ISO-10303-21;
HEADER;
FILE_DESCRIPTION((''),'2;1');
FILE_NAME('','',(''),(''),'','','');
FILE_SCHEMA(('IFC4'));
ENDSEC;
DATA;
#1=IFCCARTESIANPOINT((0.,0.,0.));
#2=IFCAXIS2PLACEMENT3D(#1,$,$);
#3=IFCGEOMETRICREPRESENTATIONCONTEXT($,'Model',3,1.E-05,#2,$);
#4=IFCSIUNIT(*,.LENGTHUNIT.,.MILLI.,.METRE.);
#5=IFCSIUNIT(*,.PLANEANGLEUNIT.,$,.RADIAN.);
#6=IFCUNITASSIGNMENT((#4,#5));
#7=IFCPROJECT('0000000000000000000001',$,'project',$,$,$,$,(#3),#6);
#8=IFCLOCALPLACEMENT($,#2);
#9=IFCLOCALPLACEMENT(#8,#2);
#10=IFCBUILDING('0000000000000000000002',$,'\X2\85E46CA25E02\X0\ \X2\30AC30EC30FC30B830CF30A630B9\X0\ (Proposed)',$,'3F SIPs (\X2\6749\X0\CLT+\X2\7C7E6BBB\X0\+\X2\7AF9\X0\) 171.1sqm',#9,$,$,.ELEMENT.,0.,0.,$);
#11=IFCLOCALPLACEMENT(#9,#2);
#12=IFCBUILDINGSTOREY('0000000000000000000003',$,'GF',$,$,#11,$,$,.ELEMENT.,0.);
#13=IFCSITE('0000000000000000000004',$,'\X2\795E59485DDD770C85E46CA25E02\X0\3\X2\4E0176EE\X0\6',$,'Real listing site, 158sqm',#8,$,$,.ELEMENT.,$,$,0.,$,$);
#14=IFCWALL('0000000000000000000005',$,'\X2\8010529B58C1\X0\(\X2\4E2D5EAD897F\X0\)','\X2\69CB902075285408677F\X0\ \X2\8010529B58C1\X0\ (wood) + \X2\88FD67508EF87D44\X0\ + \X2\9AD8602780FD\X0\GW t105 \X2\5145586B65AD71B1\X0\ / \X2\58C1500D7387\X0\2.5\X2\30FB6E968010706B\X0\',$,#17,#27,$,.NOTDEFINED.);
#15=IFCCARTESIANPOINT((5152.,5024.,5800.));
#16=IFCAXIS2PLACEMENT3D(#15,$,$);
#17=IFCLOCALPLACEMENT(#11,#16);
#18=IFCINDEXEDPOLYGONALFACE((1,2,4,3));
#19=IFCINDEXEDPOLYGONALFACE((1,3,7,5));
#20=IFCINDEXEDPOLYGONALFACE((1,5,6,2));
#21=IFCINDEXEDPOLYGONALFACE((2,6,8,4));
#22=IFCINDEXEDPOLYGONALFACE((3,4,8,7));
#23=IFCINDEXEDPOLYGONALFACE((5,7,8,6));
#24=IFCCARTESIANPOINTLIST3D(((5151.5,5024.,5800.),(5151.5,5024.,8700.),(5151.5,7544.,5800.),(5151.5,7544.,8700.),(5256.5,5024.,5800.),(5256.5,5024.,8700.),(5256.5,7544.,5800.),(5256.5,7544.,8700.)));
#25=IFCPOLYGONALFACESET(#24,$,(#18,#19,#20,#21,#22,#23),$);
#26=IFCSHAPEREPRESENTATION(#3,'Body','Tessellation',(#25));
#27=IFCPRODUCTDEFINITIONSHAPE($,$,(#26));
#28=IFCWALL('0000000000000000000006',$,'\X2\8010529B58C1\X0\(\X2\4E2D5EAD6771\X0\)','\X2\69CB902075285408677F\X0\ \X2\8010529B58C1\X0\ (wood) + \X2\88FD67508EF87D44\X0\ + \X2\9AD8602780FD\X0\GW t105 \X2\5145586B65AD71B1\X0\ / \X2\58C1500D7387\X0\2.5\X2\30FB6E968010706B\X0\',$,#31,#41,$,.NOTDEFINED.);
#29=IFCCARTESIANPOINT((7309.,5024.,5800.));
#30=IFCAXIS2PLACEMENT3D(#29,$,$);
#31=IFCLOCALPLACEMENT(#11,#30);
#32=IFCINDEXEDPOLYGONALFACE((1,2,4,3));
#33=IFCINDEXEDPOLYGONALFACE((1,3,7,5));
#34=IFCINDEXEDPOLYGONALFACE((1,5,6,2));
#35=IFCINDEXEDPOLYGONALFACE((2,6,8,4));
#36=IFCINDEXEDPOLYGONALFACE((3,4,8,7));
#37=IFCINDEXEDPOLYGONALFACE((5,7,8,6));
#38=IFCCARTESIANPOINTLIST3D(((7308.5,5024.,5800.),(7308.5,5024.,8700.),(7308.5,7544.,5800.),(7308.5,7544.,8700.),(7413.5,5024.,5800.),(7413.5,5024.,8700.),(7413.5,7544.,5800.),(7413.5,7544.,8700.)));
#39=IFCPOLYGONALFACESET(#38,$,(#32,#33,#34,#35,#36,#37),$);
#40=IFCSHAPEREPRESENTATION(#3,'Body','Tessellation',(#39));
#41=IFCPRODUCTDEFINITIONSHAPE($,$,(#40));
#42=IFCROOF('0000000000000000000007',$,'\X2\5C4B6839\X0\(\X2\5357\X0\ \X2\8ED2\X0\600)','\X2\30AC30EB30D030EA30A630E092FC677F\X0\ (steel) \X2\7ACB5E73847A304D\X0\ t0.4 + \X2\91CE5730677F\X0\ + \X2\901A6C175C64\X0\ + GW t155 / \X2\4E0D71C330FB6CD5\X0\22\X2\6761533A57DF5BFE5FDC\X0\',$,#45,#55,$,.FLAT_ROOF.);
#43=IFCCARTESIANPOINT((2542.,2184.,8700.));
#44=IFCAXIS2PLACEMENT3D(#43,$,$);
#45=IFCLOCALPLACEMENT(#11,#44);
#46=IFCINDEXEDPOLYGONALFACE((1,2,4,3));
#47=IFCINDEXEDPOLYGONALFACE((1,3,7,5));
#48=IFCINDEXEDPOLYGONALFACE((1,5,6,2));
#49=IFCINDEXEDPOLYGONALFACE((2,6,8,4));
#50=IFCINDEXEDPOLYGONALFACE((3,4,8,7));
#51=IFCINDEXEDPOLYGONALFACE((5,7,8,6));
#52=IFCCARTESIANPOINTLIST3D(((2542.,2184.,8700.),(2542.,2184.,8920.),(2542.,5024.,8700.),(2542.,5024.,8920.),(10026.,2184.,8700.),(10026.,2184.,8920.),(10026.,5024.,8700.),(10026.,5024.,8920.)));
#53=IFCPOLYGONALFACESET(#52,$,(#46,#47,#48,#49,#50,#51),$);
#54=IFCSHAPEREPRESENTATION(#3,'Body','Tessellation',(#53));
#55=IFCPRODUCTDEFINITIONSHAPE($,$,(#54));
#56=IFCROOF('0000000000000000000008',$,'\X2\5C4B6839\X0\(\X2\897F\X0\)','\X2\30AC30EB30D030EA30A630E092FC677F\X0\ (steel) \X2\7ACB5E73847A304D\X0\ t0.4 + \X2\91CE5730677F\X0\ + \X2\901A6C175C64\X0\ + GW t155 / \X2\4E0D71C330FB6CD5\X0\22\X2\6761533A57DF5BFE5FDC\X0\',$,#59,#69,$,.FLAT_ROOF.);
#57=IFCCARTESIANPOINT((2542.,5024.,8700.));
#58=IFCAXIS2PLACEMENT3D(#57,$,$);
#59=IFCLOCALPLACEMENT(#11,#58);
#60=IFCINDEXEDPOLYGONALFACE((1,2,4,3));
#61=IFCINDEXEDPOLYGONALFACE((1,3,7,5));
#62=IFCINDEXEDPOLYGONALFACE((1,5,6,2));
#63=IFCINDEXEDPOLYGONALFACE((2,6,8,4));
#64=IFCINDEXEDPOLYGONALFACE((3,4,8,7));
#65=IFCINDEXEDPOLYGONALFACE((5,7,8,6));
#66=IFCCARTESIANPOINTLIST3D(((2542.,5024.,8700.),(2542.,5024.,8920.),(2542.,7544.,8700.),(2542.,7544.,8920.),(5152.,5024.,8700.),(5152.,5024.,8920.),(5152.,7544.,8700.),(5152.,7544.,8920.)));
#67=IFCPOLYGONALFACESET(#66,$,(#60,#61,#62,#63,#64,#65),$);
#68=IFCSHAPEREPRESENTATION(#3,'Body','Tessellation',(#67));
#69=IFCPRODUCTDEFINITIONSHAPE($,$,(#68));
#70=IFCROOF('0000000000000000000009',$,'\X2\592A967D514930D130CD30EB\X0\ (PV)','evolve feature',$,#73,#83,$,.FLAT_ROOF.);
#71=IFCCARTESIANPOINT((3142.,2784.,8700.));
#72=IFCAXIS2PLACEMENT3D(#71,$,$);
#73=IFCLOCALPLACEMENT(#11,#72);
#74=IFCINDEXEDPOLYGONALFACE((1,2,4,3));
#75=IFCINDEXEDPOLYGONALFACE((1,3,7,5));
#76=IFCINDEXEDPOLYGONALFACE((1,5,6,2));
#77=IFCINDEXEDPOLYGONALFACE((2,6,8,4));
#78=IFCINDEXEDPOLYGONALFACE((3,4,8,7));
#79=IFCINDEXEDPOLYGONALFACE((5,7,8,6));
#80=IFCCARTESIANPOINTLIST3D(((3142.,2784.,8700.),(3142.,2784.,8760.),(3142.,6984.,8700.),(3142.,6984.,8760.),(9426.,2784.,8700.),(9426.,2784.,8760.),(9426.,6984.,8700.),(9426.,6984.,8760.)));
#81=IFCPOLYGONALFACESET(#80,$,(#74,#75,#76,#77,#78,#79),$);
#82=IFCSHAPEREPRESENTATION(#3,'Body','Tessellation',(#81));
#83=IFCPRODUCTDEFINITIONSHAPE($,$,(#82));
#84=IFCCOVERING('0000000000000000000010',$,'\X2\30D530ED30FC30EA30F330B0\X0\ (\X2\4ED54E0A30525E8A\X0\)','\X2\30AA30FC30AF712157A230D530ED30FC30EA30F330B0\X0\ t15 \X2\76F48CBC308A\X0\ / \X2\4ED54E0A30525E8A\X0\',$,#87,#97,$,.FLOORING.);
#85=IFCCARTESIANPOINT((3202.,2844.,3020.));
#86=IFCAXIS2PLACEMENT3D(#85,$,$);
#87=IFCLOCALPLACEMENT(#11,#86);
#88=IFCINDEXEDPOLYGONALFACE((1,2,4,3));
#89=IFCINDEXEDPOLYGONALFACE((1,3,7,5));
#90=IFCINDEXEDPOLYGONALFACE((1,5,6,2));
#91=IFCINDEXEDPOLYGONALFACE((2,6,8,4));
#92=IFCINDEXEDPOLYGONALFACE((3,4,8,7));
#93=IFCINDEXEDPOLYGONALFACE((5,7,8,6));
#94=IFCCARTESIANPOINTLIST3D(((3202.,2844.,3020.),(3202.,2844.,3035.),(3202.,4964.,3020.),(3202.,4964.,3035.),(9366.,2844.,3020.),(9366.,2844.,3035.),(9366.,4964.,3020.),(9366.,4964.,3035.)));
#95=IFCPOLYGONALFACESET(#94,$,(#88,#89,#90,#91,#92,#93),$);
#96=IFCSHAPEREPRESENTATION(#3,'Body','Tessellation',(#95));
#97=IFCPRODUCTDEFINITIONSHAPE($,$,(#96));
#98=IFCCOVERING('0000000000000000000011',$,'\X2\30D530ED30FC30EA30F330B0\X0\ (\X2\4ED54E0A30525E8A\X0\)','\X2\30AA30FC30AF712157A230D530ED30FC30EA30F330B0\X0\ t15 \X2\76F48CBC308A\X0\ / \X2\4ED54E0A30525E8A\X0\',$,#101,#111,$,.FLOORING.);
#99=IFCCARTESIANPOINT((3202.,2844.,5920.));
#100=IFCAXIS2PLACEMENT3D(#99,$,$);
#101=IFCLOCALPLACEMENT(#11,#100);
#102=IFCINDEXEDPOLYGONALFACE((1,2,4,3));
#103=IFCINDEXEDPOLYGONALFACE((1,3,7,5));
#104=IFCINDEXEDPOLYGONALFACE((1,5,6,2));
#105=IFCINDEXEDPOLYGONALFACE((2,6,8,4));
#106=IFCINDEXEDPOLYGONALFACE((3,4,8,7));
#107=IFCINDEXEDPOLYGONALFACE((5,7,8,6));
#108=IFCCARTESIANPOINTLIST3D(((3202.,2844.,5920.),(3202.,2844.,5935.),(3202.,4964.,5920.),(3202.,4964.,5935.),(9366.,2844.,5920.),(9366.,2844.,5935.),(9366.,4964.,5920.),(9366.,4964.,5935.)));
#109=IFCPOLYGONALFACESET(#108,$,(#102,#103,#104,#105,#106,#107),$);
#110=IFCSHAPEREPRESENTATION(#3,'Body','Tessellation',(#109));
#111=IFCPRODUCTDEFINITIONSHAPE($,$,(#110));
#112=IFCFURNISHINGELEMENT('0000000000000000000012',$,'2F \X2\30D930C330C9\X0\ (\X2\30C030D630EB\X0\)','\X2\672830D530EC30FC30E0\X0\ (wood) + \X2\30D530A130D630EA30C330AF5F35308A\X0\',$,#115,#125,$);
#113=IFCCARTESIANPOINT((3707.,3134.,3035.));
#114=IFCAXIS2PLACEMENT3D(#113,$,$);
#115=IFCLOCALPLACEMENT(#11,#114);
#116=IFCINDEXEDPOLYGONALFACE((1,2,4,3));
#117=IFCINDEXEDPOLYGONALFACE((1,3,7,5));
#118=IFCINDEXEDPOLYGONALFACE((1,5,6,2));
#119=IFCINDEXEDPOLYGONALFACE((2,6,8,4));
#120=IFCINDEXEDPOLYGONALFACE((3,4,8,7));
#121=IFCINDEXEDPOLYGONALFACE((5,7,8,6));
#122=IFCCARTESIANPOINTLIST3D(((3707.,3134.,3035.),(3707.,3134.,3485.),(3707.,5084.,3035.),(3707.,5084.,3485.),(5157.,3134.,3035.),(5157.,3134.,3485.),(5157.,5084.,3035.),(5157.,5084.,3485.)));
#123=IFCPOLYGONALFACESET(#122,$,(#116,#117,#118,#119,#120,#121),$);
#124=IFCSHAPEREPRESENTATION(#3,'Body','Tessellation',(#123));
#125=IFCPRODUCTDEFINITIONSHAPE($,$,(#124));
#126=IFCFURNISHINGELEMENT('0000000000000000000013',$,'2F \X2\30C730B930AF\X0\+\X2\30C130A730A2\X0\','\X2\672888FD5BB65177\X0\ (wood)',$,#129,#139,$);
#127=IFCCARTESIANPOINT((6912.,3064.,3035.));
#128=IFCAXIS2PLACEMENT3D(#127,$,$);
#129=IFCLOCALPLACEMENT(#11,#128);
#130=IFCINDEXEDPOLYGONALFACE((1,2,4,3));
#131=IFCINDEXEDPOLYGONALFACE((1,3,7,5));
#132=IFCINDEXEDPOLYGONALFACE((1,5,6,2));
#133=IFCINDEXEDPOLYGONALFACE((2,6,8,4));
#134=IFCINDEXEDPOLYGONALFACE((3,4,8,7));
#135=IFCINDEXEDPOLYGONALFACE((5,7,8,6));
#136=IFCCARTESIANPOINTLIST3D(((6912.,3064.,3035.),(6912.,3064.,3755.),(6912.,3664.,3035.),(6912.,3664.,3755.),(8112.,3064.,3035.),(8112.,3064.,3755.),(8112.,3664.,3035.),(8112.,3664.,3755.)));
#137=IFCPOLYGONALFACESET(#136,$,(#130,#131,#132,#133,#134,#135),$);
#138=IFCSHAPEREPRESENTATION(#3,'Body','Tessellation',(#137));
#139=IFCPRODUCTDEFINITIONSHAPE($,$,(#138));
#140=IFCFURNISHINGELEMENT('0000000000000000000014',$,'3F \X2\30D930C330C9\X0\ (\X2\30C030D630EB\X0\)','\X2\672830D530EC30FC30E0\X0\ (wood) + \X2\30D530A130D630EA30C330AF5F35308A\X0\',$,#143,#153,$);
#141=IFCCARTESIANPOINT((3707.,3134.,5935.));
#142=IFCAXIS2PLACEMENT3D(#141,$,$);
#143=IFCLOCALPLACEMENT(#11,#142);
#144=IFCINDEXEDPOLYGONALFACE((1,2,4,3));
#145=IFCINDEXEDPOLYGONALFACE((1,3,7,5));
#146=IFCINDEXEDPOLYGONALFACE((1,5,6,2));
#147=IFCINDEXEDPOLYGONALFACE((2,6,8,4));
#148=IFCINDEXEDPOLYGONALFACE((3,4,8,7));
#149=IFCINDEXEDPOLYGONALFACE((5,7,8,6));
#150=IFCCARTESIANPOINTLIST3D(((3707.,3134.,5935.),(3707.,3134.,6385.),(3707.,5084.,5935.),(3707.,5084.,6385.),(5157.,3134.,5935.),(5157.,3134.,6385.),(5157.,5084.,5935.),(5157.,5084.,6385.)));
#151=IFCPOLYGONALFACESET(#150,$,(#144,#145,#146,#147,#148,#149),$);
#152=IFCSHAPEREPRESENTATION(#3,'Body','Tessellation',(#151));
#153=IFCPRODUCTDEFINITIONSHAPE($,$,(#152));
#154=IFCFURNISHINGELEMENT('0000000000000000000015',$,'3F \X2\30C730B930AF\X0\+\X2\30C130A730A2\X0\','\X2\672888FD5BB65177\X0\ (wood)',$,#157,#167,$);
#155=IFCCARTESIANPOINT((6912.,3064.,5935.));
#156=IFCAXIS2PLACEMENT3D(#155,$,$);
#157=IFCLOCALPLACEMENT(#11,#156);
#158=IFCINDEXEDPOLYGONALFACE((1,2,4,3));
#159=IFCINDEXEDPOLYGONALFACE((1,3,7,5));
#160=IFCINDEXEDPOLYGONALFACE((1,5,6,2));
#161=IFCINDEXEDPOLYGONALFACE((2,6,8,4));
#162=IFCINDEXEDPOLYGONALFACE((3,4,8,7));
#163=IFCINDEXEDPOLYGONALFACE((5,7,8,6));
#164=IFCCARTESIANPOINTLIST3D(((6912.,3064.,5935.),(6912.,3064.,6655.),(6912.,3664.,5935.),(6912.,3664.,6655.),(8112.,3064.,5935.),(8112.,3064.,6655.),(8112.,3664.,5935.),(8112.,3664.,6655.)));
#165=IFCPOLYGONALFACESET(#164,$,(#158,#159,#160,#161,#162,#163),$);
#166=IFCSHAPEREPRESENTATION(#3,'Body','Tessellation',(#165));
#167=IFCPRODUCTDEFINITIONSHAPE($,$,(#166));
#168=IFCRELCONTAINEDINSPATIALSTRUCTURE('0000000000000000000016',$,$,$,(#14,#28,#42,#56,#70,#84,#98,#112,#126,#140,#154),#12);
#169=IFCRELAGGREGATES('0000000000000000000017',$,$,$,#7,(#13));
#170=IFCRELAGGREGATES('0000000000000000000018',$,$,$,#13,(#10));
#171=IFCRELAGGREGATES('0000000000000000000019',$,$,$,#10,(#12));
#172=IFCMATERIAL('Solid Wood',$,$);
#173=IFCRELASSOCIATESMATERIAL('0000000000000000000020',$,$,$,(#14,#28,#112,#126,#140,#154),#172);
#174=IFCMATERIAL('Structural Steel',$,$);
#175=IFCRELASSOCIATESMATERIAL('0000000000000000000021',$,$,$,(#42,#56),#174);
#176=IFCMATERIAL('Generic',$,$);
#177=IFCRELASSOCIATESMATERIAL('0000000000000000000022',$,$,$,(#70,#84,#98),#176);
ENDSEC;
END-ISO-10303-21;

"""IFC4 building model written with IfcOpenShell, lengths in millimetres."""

from ifc_helpers import new_model, si_unit, frame, frame_2d, origin, place, context, project, spatial, rectangle, extrude, material, element, save


model = new_model("IFC4")

# Units and contexts
model_context = context("Model", 3, precision=1e-05, world=origin())
ifc_project = project(units=[si_unit("LENGTHUNIT", "METRE", prefix="MILLI"), si_unit("PLANEANGLEUNIT", "RADIAN")], contexts=[model_context])

# Site, building, storey
site_placement = place(None, origin())
site = spatial("IfcSite", under=ifc_project, at=site_placement, Name="神奈川県藤沢市3丁目6", ObjectType="Real listing site, 158sqm", CompositionType="ELEMENT", RefElevation=0.0)
building_placement = place(site_placement, origin())
building = spatial("IfcBuilding", under=site, at=building_placement, Name="藤沢市 ガレージハウス (Proposed)", ObjectType="3F SIPs (杉CLT+籾殻+竹) 171.1sqm", CompositionType="ELEMENT", ElevationOfRefHeight=0.0, ElevationOfTerrain=0.0)
storey_placement = place(building_placement, origin())
storey = spatial("IfcBuildingStorey", under=building, at=storey_placement, Name="GF", CompositionType="ELEMENT", Elevation=0.0)

# Shared definitions
ifc_material_1 = material(Name="Solid Wood")

# Walls
wall_1_placement = place(storey_placement, frame((5152.0, 5024.0, 5800.0)))
element("IfcWall", 1, at=wall_1_placement, inside=storey, material=ifc_material_1, Name="耐力壁(中庭西)", Description="構造用合板 耐力壁 (wood) + 製材軸組 + 高性能GW t105 充填断熱 / 壁倍率2.5・準耐火", PredefinedType="NOTDEFINED", context=model_context, shape_type="SweptSolid", body=[
    extrude(rectangle(XDim=105.0, YDim=2520.0, at=frame_2d((52.0, 1260.0))), frame((5152.0, 5024.0, 5800.0)), (0.0, 0.0, 1.0), 2900.0),
])
wall_2_placement = place(storey_placement, frame((7309.0, 5024.0, 5800.0)))
element("IfcWall", 2, at=wall_2_placement, inside=storey, material=ifc_material_1, Name="耐力壁(中庭東)", Description="構造用合板 耐力壁 (wood) + 製材軸組 + 高性能GW t105 充填断熱 / 壁倍率2.5・準耐火", PredefinedType="NOTDEFINED", context=model_context, shape_type="SweptSolid", body=[
    extrude(rectangle(XDim=105.0, YDim=2520.0, at=frame_2d((52.0, 1260.0))), frame((7309.0, 5024.0, 5800.0)), (0.0, 0.0, 1.0), 2900.0),
])

# Roofs
ifc_material_2 = material(Name="Structural Steel")
roof_1_placement = place(storey_placement, frame((2542.0, 2184.0, 8700.0)))
element("IfcRoof", 3, at=roof_1_placement, inside=storey, material=ifc_material_2, Name="屋根(南 軒600)", Description="ガルバリウム鋼板 (steel) 立平葺き t0.4 + 野地板 + 通気層 + GW t155 / 不燃・法22条区域対応", PredefinedType="FLAT_ROOF", context=model_context, shape_type="SweptSolid", body=[
    extrude(rectangle(XDim=7484.0, YDim=2840.0, at=frame_2d((3742.0, 1420.0))), frame((2542.0, 2184.0, 8700.0)), (0.0, 0.0, 1.0), 220.0),
])
roof_2_placement = place(storey_placement, frame((2542.0, 5024.0, 8700.0)))
element("IfcRoof", 4, at=roof_2_placement, inside=storey, material=ifc_material_2, Name="屋根(西)", Description="ガルバリウム鋼板 (steel) 立平葺き t0.4 + 野地板 + 通気層 + GW t155 / 不燃・法22条区域対応", PredefinedType="FLAT_ROOF", context=model_context, shape_type="SweptSolid", body=[
    extrude(rectangle(XDim=2610.0, YDim=2520.0, at=frame_2d((1305.0, 1260.0))), frame((2542.0, 5024.0, 8700.0)), (0.0, 0.0, 1.0), 220.0),
])
ifc_material_3 = material(Name="Generic")
roof_3_placement = place(storey_placement, frame((3142.0, 2784.0, 8700.0)))
element("IfcRoof", 5, at=roof_3_placement, inside=storey, material=ifc_material_3, Name="太陽光パネル (PV)", Description="evolve feature", PredefinedType="FLAT_ROOF", context=model_context, shape_type="SweptSolid", body=[
    extrude(rectangle(XDim=6284.0, YDim=4200.0, at=frame_2d((3142.0, 2100.0))), frame((3142.0, 2784.0, 8700.0)), (0.0, 0.0, 1.0), 60.0),
])

# Coverings
covering_1_placement = place(storey_placement, frame((3202.0, 2844.0, 3020.0)))
element("IfcCovering", 6, at=covering_1_placement, inside=storey, material=ifc_material_3, Name="フローリング (仕上げ床)", Description="オーク無垢フローリング t15 直貼り / 仕上げ床", PredefinedType="FLOORING", context=model_context, shape_type="SweptSolid", body=[
    extrude(rectangle(XDim=6164.0, YDim=2120.0, at=frame_2d((3082.0, 1060.0))), frame((3202.0, 2844.0, 3020.0)), (0.0, 0.0, 1.0), 15.0),
])
covering_2_placement = place(storey_placement, frame((3202.0, 2844.0, 5920.0)))
element("IfcCovering", 7, at=covering_2_placement, inside=storey, material=ifc_material_3, Name="フローリング (仕上げ床)", Description="オーク無垢フローリング t15 直貼り / 仕上げ床", PredefinedType="FLOORING", context=model_context, shape_type="SweptSolid", body=[
    extrude(rectangle(XDim=6164.0, YDim=2120.0, at=frame_2d((3082.0, 1060.0))), frame((3202.0, 2844.0, 5920.0)), (0.0, 0.0, 1.0), 15.0),
])

# Furnishing elements
furnishing_1_placement = place(storey_placement, frame((3707.0, 3134.0, 3035.0)))
element("IfcFurnishingElement", 8, at=furnishing_1_placement, inside=storey, material=ifc_material_1, Name="2F ベッド (ダブル)", Description="木フレーム (wood) + ファブリック張り", context=model_context, shape_type="SweptSolid", body=[
    extrude(rectangle(XDim=1450.0, YDim=1950.0, at=frame_2d((725.0, 975.0))), frame((3707.0, 3134.0, 3035.0)), (0.0, 0.0, 1.0), 450.0),
])
furnishing_2_placement = place(storey_placement, frame((6912.0, 3064.0, 3035.0)))
element("IfcFurnishingElement", 9, at=furnishing_2_placement, inside=storey, material=ifc_material_1, Name="2F デスク+チェア", Description="木製家具 (wood)", context=model_context, shape_type="SweptSolid", body=[
    extrude(rectangle(XDim=1200.0, YDim=600.0, at=frame_2d((600.0, 300.0))), frame((6912.0, 3064.0, 3035.0)), (0.0, 0.0, 1.0), 720.0),
])
furnishing_3_placement = place(storey_placement, frame((3707.0, 3134.0, 5935.0)))
element("IfcFurnishingElement", 10, at=furnishing_3_placement, inside=storey, material=ifc_material_1, Name="3F ベッド (ダブル)", Description="木フレーム (wood) + ファブリック張り", context=model_context, shape_type="SweptSolid", body=[
    extrude(rectangle(XDim=1450.0, YDim=1950.0, at=frame_2d((725.0, 975.0))), frame((3707.0, 3134.0, 5935.0)), (0.0, 0.0, 1.0), 450.0),
])
furnishing_4_placement = place(storey_placement, frame((6912.0, 3064.0, 5935.0)))
element("IfcFurnishingElement", 11, at=furnishing_4_placement, inside=storey, material=ifc_material_1, Name="3F デスク+チェア", Description="木製家具 (wood)", context=model_context, shape_type="SweptSolid", body=[
    extrude(rectangle(XDim=1200.0, YDim=600.0, at=frame_2d((600.0, 300.0))), frame((6912.0, 3064.0, 5935.0)), (0.0, 0.0, 1.0), 720.0),
])

save(model, "model.ifc")
